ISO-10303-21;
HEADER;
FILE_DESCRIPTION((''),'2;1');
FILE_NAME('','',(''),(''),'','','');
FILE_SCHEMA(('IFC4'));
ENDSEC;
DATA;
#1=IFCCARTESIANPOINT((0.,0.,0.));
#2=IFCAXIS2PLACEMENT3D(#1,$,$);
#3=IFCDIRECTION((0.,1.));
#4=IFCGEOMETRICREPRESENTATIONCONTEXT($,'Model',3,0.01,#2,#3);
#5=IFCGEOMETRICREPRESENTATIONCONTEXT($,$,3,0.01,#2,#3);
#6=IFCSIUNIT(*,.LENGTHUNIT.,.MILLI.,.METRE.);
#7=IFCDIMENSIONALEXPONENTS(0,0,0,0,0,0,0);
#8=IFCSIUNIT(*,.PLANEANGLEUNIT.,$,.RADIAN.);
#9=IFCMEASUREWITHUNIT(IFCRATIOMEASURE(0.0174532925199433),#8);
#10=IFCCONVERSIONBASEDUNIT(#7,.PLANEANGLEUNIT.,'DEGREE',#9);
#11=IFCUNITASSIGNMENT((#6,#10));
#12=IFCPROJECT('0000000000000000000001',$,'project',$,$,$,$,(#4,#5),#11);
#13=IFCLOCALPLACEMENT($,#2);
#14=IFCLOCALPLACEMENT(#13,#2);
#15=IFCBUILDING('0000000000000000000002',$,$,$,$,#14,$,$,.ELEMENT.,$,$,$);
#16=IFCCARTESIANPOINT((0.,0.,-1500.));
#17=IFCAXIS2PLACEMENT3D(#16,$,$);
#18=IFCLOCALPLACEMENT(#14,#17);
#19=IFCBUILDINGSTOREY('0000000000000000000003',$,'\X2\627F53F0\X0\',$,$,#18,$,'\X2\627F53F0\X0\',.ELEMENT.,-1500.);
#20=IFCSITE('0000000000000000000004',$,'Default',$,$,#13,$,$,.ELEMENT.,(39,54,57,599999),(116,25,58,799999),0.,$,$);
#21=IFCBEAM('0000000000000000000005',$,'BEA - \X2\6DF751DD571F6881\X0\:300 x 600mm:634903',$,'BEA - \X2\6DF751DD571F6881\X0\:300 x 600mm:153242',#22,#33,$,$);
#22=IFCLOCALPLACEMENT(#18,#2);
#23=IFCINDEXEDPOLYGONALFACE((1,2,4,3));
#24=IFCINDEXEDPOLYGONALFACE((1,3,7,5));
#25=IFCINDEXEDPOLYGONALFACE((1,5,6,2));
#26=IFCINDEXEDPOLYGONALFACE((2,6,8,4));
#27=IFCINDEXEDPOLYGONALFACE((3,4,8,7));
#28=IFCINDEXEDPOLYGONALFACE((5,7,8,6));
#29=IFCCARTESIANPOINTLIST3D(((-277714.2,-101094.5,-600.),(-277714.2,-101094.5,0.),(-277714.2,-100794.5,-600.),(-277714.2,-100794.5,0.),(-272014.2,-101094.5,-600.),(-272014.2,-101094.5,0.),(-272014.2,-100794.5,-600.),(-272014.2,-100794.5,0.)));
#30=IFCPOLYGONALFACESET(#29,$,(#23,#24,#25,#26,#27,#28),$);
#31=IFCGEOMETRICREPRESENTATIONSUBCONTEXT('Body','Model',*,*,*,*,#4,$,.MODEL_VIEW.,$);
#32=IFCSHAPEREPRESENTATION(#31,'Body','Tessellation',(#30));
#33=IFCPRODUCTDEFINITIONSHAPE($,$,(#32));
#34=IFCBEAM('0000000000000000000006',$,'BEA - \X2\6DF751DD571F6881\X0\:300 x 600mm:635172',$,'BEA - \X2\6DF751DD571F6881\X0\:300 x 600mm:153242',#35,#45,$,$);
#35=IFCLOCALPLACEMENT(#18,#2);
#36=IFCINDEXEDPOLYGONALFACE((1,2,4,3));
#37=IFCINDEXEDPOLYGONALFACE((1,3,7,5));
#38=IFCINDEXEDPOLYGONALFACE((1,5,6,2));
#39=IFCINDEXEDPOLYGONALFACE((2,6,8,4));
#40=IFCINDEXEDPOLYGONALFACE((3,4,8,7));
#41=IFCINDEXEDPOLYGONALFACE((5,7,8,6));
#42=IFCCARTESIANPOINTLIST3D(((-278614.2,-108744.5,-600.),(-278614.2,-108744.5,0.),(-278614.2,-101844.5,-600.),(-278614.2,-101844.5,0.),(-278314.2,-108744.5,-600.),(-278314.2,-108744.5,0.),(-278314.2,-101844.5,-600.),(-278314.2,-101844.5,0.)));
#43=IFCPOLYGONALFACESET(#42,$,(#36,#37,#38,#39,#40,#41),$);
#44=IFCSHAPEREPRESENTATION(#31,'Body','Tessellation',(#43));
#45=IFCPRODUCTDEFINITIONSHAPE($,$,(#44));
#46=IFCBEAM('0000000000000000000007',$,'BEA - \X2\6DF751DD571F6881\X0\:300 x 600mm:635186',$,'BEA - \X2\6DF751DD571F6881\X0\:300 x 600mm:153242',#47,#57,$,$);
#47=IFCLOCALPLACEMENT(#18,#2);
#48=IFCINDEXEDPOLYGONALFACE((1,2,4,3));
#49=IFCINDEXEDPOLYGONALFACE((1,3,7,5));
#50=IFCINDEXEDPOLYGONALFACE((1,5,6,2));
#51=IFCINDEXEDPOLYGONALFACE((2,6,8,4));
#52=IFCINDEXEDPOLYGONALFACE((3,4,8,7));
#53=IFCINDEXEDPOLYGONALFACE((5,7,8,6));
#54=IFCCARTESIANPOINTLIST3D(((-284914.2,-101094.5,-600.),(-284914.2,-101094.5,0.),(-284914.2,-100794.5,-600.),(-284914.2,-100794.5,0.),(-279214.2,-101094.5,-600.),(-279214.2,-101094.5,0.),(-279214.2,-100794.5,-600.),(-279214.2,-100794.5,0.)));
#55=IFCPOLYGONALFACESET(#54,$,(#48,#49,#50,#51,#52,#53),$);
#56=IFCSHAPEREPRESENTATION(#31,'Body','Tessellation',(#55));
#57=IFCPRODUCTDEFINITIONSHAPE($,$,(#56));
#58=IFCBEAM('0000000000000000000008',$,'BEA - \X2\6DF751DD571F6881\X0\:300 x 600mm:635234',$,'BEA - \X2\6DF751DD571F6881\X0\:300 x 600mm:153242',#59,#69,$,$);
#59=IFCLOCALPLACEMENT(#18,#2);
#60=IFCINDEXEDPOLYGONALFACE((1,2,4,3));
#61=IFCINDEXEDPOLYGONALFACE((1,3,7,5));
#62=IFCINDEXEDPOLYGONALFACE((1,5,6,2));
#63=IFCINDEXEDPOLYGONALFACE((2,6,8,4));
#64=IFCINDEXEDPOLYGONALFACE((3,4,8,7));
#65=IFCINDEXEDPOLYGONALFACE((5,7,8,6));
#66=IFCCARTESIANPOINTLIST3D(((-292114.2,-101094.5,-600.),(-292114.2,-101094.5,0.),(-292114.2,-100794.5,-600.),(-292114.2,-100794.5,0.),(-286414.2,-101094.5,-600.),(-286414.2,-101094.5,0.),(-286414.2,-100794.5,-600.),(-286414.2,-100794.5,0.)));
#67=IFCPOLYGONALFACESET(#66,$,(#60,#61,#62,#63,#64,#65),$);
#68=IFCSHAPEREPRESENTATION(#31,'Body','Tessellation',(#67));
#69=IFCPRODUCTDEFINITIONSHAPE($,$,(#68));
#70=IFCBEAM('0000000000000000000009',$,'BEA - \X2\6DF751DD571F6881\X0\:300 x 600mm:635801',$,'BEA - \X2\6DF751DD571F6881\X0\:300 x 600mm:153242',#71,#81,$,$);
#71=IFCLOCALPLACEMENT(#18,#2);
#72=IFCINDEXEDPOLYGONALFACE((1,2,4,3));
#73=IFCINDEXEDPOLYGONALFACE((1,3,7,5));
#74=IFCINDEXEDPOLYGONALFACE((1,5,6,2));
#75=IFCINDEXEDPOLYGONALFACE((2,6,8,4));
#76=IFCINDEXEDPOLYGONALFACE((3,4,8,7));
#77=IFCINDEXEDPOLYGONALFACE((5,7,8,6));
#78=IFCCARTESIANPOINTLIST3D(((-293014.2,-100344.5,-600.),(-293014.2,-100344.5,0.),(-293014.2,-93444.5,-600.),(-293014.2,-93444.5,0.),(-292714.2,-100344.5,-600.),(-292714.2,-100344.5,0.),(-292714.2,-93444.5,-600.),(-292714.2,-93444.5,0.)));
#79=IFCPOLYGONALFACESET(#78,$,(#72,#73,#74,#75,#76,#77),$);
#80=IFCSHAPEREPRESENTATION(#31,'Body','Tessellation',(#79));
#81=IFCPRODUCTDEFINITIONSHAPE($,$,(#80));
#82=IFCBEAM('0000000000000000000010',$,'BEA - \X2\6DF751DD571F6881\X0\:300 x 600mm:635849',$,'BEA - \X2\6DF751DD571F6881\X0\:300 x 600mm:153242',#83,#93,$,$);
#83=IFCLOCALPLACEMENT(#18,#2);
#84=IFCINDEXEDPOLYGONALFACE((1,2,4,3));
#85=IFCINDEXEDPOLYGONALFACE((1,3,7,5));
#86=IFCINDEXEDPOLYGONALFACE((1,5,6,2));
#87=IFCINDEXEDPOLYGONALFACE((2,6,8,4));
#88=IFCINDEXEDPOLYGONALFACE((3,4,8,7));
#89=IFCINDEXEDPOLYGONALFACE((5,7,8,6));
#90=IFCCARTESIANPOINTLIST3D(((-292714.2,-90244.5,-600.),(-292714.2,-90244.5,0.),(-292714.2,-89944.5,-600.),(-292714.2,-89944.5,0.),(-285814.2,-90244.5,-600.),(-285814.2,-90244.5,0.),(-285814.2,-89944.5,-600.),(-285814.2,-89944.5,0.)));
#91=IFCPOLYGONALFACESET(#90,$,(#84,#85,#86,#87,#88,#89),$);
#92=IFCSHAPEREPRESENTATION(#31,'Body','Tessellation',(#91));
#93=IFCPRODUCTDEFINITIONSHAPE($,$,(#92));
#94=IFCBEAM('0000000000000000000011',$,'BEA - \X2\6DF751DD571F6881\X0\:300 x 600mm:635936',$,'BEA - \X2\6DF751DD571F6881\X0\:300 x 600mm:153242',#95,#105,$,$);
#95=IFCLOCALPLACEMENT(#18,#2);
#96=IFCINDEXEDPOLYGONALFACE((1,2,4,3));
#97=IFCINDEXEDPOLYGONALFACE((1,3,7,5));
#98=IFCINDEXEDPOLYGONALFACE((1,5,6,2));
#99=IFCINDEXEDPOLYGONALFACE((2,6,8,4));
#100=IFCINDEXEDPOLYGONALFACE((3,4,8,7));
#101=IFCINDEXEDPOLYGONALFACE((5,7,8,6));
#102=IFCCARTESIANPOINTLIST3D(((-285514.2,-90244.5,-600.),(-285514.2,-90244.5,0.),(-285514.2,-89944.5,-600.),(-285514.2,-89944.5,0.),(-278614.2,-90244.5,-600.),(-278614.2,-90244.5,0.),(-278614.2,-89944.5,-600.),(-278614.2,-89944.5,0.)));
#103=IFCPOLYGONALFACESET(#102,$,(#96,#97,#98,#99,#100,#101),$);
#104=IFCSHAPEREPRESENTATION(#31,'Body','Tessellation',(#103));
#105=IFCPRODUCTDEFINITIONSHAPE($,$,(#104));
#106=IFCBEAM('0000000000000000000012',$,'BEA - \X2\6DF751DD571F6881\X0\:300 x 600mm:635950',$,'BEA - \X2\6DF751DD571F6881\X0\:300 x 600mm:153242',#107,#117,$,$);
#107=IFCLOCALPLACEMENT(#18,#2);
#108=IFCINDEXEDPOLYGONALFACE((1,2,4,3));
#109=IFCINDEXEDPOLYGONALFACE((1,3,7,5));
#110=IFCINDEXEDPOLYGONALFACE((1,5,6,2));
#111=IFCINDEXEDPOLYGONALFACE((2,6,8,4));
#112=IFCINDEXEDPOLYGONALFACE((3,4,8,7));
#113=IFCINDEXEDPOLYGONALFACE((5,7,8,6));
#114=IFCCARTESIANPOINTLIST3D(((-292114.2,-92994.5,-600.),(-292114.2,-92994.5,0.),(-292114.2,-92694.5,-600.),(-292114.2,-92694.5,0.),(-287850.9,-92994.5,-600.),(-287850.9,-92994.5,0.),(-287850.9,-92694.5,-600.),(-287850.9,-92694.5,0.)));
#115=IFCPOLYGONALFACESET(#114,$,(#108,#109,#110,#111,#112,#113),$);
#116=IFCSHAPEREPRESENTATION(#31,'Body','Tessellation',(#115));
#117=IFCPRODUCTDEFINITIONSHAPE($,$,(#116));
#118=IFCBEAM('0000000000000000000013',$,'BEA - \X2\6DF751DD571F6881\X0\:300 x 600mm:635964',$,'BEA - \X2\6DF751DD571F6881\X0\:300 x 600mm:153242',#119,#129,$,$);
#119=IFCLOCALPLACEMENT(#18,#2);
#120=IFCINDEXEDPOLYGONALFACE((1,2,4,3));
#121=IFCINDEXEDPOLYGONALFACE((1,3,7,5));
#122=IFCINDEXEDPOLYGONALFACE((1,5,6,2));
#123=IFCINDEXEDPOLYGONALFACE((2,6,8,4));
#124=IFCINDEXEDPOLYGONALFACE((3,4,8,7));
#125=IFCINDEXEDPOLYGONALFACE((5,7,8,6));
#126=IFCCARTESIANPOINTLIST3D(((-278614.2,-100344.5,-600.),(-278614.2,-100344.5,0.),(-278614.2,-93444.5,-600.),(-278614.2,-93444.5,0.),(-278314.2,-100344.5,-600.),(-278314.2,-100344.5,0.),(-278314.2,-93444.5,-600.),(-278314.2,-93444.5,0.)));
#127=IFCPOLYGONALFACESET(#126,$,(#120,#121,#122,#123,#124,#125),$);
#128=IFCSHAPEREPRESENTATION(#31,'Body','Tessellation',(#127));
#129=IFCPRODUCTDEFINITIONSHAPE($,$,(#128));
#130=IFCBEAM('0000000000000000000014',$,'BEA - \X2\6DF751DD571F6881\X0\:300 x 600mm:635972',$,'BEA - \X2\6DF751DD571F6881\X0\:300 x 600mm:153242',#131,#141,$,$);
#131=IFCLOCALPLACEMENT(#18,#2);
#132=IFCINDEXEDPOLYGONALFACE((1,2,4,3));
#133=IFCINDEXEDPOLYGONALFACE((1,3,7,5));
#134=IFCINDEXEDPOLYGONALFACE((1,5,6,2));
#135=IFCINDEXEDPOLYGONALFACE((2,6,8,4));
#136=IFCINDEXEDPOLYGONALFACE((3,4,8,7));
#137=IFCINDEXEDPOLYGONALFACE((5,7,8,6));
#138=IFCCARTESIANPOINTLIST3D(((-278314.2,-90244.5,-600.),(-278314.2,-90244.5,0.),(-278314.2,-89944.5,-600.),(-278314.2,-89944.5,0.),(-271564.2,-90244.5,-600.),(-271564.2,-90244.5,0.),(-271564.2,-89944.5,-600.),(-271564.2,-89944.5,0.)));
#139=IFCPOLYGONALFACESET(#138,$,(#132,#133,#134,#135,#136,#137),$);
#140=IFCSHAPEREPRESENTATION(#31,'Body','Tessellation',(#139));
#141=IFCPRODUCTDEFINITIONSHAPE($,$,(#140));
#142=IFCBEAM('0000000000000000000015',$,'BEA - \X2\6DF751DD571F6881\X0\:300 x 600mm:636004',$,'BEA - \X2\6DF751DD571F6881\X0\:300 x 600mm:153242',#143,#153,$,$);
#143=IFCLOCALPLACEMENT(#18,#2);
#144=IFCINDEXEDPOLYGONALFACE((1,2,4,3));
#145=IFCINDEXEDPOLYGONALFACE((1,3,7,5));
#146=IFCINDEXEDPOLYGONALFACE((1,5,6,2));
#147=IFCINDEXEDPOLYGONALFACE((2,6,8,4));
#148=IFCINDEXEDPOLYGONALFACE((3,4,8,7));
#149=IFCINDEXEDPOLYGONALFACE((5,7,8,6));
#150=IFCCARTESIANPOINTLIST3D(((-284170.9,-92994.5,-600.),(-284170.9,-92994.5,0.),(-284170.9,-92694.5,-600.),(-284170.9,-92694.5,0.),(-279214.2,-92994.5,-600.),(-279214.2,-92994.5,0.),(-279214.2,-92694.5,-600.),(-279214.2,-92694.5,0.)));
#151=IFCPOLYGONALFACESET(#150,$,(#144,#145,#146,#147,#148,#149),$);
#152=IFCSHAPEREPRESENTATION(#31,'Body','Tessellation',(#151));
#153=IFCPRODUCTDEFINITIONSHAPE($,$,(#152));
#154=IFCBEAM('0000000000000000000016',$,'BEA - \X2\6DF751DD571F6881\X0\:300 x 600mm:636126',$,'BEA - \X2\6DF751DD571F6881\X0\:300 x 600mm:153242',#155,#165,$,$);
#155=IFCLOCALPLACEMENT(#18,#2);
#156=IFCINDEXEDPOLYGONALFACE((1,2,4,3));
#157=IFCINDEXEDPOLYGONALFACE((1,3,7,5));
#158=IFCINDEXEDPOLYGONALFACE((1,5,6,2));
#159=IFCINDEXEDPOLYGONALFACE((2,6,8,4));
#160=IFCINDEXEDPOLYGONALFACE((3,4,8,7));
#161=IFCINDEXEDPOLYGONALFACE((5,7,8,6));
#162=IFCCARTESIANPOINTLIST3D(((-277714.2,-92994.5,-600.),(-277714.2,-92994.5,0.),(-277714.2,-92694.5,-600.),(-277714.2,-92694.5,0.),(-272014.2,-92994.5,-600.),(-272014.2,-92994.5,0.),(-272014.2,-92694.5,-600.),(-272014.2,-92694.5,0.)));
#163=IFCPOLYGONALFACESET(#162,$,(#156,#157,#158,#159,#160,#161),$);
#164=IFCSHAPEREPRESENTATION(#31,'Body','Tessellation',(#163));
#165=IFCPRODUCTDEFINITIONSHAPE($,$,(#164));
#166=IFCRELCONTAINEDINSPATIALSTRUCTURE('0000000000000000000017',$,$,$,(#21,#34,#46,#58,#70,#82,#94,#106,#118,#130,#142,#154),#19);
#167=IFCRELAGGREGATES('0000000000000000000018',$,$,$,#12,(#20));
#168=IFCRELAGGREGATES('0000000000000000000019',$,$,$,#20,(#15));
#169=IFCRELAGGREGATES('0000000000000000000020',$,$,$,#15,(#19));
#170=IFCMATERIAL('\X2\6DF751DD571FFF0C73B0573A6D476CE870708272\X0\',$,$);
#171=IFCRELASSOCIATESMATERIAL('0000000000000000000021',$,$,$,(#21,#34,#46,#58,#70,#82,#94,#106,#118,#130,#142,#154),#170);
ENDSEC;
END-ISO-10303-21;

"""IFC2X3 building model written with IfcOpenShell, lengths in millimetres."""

from ifc_helpers import new_model, entity, si_unit, converted_unit, direction, frame, frame_2d, origin, origin_2d_with_axis, place, context, subcontext, project, spatial, rectangle, extrude, material, element, save


model = new_model("IFC2X3")

# Units and contexts
model_context = context("Model", 3, precision=0.01, world=origin(), true_north=direction((0.0, 1.0)))
context_of_model = context(None, 3, precision=0.01, world=origin(), true_north=direction((0.0, 1.0)))
body_context = subcontext(model_context, "Body", "Model", "MODEL_VIEW")
ifc_project = project(units=[si_unit("LENGTHUNIT", "METRE", prefix="MILLI"), converted_unit("PLANEANGLEUNIT", "DEGREE", entity("IfcRatioMeasure", 0.0174532925199433), si_unit("PLANEANGLEUNIT", "RADIAN"), dimensions=[0, 0, 0, 0, 0, 0, 0])], contexts=[model_context, context_of_model])

# Site, building, storey
site_placement = place(None, origin())
site = spatial("IfcSite", under=ifc_project, at=site_placement, Name="Default", CompositionType="ELEMENT", RefLatitude=(39, 54, 57, 599999), RefLongitude=(116, 25, 58, 799999), RefElevation=0.0)
building_placement = place(site_placement, origin())
building = spatial("IfcBuilding", under=site, at=building_placement, CompositionType="ELEMENT")
storey_placement = place(building_placement, frame((0.0, 0.0, -1500.0)))
storey = spatial("IfcBuildingStorey", under=building, at=storey_placement, Name="承台", LongName="承台", CompositionType="ELEMENT", Elevation=-1500.0)

# Shared definitions
ifc_material_1 = material(Name="混凝土，现场浇注灰色")

# Beams
beam_1_placement = place(storey_placement, frame((-272014.2, -100944.5, 0.0), z_axis=(0.0, 0.0, 1.0), x_axis=(-1.0, 0.0, 0.0)))
element("IfcBeam", 1, at=beam_1_placement, inside=storey, material=ifc_material_1, Name="BEA - 混凝土梁:300 x 600mm:634903", ObjectType="BEA - 混凝土梁:300 x 600mm:153242", context=body_context, shape_type="SweptSolid", body=[
    extrude(rectangle(XDim=600.0, YDim=300.0, at=frame_2d((0.0, 0.0), x_axis=(1.0, 0.0))), frame((0.0, 0.0, -300.0), z_axis=(1.0, 0.0, 0.0), x_axis=(0.0, 0.0, -1.0)), (0.0, 0.0, 1.0), 5700.0),
])
beam_2_placement = place(storey_placement, frame((-278464.2, -101844.5, 0.0), z_axis=(0.0, 0.0, 1.0), x_axis=(0.0, -1.0, 0.0)))
element("IfcBeam", 2, at=beam_2_placement, inside=storey, material=ifc_material_1, Name="BEA - 混凝土梁:300 x 600mm:635172", ObjectType="BEA - 混凝土梁:300 x 600mm:153242", context=body_context, shape_type="SweptSolid", body=[
    extrude(rectangle(XDim=600.0, YDim=300.0, at=origin_2d_with_axis()), frame((0.0, 0.0, -300.0), z_axis=(1.0, 0.0, 0.0), x_axis=(0.0, 0.0, -1.0)), (0.0, 0.0, 1.0), 6900.0),
])
for number, where, z_axis, x_axis, name in (
    (3, (-279214.2, -100944.5, 0.0), (0.0, 0.0, 1.0), (-1.0, 0.0, 0.0), "BEA - 混凝土梁:300 x 600mm:635186"),
    (4, (-286414.2, -100944.5, 0.0), (0.0, 0.0, 1.0), (-1.0, 0.0, 0.0), "BEA - 混凝土梁:300 x 600mm:635234"),
):
    element("IfcBeam", number, at=place(storey_placement, frame(where, z_axis=z_axis, x_axis=x_axis)), inside=storey, material=ifc_material_1, Name=name, ObjectType="BEA - 混凝土梁:300 x 600mm:153242", context=body_context, shape_type="SweptSolid", body=[
        extrude(rectangle(XDim=600.0, YDim=300.0, at=frame_2d((0.0, 0.0), x_axis=(1.0, 0.0))), frame((0.0, 0.0, -300.0), z_axis=(1.0, 0.0, 0.0), x_axis=(0.0, 0.0, -1.0)), (0.0, 0.0, 1.0), 5700.0),
    ])
beam_3_placement = place(storey_placement, frame((-292864.2, -93444.5, 0.0), z_axis=(0.0, 0.0, 1.0), x_axis=(0.0, -1.0, 0.0)))
element("IfcBeam", 5, at=beam_3_placement, inside=storey, material=ifc_material_1, Name="BEA - 混凝土梁:300 x 600mm:635801", ObjectType="BEA - 混凝土梁:300 x 600mm:153242", context=body_context, shape_type="SweptSolid", body=[
    extrude(rectangle(XDim=600.0, YDim=300.0, at=origin_2d_with_axis()), frame((0.0, 0.0, -300.0), z_axis=(1.0, 0.0, 0.0), x_axis=(0.0, 0.0, -1.0)), (0.0, 0.0, 1.0), 6900.0),
])
beam_4_placement = place(storey_placement, frame((-292714.2, -90094.5, 0.0)))
element("IfcBeam", 6, at=beam_4_placement, inside=storey, material=ifc_material_1, Name="BEA - 混凝土梁:300 x 600mm:635849", ObjectType="BEA - 混凝土梁:300 x 600mm:153242", context=body_context, shape_type="SweptSolid", body=[
    extrude(rectangle(XDim=600.0, YDim=300.0, at=frame_2d((0.0, 0.0), x_axis=(1.0, 0.0))), frame((0.0, 0.0, -300.0), z_axis=(1.0, 0.0, 0.0), x_axis=(0.0, 0.0, -1.0)), (0.0, 0.0, 1.0), 6900.0),
])
beam_5_placement = place(storey_placement, frame((-285514.2, -90094.5, 0.0)))
element("IfcBeam", 7, at=beam_5_placement, inside=storey, material=ifc_material_1, Name="BEA - 混凝土梁:300 x 600mm:635936", ObjectType="BEA - 混凝土梁:300 x 600mm:153242", context=body_context, shape_type="SweptSolid", body=[
    extrude(rectangle(XDim=600.0, YDim=300.0, at=frame_2d((0.0, 0.0), x_axis=(1.0, 0.0))), frame((0.0, 0.0, -300.0), z_axis=(1.0, 0.0, 0.0), x_axis=(0.0, 0.0, -1.0)), (0.0, 0.0, 1.0), 6900.0),
])
beam_6_placement = place(storey_placement, frame((-287850.9, -92844.5, 0.0), z_axis=(0.0, 0.0, 1.0), x_axis=(-1.0, 0.0, 0.0)))
element("IfcBeam", 8, at=beam_6_placement, inside=storey, material=ifc_material_1, Name="BEA - 混凝土梁:300 x 600mm:635950", ObjectType="BEA - 混凝土梁:300 x 600mm:153242", context=body_context, shape_type="SweptSolid", body=[
    extrude(rectangle(XDim=600.0, YDim=300.0, at=frame_2d((0.0, 0.0), x_axis=(1.0, 0.0))), frame((0.0, 0.0, -300.0), z_axis=(1.0, 0.0, 0.0), x_axis=(0.0, 0.0, -1.0)), (0.0, 0.0, 1.0), 4263.3),
])
beam_7_placement = place(storey_placement, frame((-278464.2, -93444.5, 0.0), z_axis=(0.0, 0.0, 1.0), x_axis=(0.0, -1.0, 0.0)))
element("IfcBeam", 9, at=beam_7_placement, inside=storey, material=ifc_material_1, Name="BEA - 混凝土梁:300 x 600mm:635964", ObjectType="BEA - 混凝土梁:300 x 600mm:153242", context=body_context, shape_type="SweptSolid", body=[
    extrude(rectangle(XDim=600.0, YDim=300.0, at=origin_2d_with_axis()), frame((0.0, 0.0, -300.0), z_axis=(1.0, 0.0, 0.0), x_axis=(0.0, 0.0, -1.0)), (0.0, 0.0, 1.0), 6900.0),
])
beam_8_placement = place(storey_placement, frame((-278314.2, -90094.5, 0.0)))
element("IfcBeam", 10, at=beam_8_placement, inside=storey, material=ifc_material_1, Name="BEA - 混凝土梁:300 x 600mm:635972", ObjectType="BEA - 混凝土梁:300 x 600mm:153242", context=body_context, shape_type="SweptSolid", body=[
    extrude(rectangle(XDim=600.0, YDim=300.0, at=frame_2d((0.0, 0.0), x_axis=(1.0, 0.0))), frame((0.0, 0.0, -300.0), z_axis=(1.0, 0.0, 0.0), x_axis=(0.0, 0.0, -1.0)), (0.0, 0.0, 1.0), 6750.0),
])
beam_9_placement = place(storey_placement, frame((-279214.2, -92844.5, 0.0), z_axis=(0.0, 0.0, 1.0), x_axis=(-1.0, 0.0, 0.0)))
element("IfcBeam", 11, at=beam_9_placement, inside=storey, material=ifc_material_1, Name="BEA - 混凝土梁:300 x 600mm:636004", ObjectType="BEA - 混凝土梁:300 x 600mm:153242", context=body_context, shape_type="SweptSolid", body=[
    extrude(rectangle(XDim=600.0, YDim=300.0, at=frame_2d((0.0, 0.0), x_axis=(1.0, 0.0))), frame((0.0, 0.0, -300.0), z_axis=(1.0, 0.0, 0.0), x_axis=(0.0, 0.0, -1.0)), (0.0, 0.0, 1.0), 4956.7),
])
beam_10_placement = place(storey_placement, frame((-272014.2, -92844.5, 0.0), z_axis=(0.0, 0.0, 1.0), x_axis=(-1.0, 0.0, 0.0)))
element("IfcBeam", 12, at=beam_10_placement, inside=storey, material=ifc_material_1, Name="BEA - 混凝土梁:300 x 600mm:636126", ObjectType="BEA - 混凝土梁:300 x 600mm:153242", context=body_context, shape_type="SweptSolid", body=[
    extrude(rectangle(XDim=600.0, YDim=300.0, at=frame_2d((0.0, 0.0), x_axis=(1.0, 0.0))), frame((0.0, 0.0, -300.0), z_axis=(1.0, 0.0, 0.0), x_axis=(0.0, 0.0, -1.0)), (0.0, 0.0, 1.0), 5700.0),
])

save(model, "model.ifc")
